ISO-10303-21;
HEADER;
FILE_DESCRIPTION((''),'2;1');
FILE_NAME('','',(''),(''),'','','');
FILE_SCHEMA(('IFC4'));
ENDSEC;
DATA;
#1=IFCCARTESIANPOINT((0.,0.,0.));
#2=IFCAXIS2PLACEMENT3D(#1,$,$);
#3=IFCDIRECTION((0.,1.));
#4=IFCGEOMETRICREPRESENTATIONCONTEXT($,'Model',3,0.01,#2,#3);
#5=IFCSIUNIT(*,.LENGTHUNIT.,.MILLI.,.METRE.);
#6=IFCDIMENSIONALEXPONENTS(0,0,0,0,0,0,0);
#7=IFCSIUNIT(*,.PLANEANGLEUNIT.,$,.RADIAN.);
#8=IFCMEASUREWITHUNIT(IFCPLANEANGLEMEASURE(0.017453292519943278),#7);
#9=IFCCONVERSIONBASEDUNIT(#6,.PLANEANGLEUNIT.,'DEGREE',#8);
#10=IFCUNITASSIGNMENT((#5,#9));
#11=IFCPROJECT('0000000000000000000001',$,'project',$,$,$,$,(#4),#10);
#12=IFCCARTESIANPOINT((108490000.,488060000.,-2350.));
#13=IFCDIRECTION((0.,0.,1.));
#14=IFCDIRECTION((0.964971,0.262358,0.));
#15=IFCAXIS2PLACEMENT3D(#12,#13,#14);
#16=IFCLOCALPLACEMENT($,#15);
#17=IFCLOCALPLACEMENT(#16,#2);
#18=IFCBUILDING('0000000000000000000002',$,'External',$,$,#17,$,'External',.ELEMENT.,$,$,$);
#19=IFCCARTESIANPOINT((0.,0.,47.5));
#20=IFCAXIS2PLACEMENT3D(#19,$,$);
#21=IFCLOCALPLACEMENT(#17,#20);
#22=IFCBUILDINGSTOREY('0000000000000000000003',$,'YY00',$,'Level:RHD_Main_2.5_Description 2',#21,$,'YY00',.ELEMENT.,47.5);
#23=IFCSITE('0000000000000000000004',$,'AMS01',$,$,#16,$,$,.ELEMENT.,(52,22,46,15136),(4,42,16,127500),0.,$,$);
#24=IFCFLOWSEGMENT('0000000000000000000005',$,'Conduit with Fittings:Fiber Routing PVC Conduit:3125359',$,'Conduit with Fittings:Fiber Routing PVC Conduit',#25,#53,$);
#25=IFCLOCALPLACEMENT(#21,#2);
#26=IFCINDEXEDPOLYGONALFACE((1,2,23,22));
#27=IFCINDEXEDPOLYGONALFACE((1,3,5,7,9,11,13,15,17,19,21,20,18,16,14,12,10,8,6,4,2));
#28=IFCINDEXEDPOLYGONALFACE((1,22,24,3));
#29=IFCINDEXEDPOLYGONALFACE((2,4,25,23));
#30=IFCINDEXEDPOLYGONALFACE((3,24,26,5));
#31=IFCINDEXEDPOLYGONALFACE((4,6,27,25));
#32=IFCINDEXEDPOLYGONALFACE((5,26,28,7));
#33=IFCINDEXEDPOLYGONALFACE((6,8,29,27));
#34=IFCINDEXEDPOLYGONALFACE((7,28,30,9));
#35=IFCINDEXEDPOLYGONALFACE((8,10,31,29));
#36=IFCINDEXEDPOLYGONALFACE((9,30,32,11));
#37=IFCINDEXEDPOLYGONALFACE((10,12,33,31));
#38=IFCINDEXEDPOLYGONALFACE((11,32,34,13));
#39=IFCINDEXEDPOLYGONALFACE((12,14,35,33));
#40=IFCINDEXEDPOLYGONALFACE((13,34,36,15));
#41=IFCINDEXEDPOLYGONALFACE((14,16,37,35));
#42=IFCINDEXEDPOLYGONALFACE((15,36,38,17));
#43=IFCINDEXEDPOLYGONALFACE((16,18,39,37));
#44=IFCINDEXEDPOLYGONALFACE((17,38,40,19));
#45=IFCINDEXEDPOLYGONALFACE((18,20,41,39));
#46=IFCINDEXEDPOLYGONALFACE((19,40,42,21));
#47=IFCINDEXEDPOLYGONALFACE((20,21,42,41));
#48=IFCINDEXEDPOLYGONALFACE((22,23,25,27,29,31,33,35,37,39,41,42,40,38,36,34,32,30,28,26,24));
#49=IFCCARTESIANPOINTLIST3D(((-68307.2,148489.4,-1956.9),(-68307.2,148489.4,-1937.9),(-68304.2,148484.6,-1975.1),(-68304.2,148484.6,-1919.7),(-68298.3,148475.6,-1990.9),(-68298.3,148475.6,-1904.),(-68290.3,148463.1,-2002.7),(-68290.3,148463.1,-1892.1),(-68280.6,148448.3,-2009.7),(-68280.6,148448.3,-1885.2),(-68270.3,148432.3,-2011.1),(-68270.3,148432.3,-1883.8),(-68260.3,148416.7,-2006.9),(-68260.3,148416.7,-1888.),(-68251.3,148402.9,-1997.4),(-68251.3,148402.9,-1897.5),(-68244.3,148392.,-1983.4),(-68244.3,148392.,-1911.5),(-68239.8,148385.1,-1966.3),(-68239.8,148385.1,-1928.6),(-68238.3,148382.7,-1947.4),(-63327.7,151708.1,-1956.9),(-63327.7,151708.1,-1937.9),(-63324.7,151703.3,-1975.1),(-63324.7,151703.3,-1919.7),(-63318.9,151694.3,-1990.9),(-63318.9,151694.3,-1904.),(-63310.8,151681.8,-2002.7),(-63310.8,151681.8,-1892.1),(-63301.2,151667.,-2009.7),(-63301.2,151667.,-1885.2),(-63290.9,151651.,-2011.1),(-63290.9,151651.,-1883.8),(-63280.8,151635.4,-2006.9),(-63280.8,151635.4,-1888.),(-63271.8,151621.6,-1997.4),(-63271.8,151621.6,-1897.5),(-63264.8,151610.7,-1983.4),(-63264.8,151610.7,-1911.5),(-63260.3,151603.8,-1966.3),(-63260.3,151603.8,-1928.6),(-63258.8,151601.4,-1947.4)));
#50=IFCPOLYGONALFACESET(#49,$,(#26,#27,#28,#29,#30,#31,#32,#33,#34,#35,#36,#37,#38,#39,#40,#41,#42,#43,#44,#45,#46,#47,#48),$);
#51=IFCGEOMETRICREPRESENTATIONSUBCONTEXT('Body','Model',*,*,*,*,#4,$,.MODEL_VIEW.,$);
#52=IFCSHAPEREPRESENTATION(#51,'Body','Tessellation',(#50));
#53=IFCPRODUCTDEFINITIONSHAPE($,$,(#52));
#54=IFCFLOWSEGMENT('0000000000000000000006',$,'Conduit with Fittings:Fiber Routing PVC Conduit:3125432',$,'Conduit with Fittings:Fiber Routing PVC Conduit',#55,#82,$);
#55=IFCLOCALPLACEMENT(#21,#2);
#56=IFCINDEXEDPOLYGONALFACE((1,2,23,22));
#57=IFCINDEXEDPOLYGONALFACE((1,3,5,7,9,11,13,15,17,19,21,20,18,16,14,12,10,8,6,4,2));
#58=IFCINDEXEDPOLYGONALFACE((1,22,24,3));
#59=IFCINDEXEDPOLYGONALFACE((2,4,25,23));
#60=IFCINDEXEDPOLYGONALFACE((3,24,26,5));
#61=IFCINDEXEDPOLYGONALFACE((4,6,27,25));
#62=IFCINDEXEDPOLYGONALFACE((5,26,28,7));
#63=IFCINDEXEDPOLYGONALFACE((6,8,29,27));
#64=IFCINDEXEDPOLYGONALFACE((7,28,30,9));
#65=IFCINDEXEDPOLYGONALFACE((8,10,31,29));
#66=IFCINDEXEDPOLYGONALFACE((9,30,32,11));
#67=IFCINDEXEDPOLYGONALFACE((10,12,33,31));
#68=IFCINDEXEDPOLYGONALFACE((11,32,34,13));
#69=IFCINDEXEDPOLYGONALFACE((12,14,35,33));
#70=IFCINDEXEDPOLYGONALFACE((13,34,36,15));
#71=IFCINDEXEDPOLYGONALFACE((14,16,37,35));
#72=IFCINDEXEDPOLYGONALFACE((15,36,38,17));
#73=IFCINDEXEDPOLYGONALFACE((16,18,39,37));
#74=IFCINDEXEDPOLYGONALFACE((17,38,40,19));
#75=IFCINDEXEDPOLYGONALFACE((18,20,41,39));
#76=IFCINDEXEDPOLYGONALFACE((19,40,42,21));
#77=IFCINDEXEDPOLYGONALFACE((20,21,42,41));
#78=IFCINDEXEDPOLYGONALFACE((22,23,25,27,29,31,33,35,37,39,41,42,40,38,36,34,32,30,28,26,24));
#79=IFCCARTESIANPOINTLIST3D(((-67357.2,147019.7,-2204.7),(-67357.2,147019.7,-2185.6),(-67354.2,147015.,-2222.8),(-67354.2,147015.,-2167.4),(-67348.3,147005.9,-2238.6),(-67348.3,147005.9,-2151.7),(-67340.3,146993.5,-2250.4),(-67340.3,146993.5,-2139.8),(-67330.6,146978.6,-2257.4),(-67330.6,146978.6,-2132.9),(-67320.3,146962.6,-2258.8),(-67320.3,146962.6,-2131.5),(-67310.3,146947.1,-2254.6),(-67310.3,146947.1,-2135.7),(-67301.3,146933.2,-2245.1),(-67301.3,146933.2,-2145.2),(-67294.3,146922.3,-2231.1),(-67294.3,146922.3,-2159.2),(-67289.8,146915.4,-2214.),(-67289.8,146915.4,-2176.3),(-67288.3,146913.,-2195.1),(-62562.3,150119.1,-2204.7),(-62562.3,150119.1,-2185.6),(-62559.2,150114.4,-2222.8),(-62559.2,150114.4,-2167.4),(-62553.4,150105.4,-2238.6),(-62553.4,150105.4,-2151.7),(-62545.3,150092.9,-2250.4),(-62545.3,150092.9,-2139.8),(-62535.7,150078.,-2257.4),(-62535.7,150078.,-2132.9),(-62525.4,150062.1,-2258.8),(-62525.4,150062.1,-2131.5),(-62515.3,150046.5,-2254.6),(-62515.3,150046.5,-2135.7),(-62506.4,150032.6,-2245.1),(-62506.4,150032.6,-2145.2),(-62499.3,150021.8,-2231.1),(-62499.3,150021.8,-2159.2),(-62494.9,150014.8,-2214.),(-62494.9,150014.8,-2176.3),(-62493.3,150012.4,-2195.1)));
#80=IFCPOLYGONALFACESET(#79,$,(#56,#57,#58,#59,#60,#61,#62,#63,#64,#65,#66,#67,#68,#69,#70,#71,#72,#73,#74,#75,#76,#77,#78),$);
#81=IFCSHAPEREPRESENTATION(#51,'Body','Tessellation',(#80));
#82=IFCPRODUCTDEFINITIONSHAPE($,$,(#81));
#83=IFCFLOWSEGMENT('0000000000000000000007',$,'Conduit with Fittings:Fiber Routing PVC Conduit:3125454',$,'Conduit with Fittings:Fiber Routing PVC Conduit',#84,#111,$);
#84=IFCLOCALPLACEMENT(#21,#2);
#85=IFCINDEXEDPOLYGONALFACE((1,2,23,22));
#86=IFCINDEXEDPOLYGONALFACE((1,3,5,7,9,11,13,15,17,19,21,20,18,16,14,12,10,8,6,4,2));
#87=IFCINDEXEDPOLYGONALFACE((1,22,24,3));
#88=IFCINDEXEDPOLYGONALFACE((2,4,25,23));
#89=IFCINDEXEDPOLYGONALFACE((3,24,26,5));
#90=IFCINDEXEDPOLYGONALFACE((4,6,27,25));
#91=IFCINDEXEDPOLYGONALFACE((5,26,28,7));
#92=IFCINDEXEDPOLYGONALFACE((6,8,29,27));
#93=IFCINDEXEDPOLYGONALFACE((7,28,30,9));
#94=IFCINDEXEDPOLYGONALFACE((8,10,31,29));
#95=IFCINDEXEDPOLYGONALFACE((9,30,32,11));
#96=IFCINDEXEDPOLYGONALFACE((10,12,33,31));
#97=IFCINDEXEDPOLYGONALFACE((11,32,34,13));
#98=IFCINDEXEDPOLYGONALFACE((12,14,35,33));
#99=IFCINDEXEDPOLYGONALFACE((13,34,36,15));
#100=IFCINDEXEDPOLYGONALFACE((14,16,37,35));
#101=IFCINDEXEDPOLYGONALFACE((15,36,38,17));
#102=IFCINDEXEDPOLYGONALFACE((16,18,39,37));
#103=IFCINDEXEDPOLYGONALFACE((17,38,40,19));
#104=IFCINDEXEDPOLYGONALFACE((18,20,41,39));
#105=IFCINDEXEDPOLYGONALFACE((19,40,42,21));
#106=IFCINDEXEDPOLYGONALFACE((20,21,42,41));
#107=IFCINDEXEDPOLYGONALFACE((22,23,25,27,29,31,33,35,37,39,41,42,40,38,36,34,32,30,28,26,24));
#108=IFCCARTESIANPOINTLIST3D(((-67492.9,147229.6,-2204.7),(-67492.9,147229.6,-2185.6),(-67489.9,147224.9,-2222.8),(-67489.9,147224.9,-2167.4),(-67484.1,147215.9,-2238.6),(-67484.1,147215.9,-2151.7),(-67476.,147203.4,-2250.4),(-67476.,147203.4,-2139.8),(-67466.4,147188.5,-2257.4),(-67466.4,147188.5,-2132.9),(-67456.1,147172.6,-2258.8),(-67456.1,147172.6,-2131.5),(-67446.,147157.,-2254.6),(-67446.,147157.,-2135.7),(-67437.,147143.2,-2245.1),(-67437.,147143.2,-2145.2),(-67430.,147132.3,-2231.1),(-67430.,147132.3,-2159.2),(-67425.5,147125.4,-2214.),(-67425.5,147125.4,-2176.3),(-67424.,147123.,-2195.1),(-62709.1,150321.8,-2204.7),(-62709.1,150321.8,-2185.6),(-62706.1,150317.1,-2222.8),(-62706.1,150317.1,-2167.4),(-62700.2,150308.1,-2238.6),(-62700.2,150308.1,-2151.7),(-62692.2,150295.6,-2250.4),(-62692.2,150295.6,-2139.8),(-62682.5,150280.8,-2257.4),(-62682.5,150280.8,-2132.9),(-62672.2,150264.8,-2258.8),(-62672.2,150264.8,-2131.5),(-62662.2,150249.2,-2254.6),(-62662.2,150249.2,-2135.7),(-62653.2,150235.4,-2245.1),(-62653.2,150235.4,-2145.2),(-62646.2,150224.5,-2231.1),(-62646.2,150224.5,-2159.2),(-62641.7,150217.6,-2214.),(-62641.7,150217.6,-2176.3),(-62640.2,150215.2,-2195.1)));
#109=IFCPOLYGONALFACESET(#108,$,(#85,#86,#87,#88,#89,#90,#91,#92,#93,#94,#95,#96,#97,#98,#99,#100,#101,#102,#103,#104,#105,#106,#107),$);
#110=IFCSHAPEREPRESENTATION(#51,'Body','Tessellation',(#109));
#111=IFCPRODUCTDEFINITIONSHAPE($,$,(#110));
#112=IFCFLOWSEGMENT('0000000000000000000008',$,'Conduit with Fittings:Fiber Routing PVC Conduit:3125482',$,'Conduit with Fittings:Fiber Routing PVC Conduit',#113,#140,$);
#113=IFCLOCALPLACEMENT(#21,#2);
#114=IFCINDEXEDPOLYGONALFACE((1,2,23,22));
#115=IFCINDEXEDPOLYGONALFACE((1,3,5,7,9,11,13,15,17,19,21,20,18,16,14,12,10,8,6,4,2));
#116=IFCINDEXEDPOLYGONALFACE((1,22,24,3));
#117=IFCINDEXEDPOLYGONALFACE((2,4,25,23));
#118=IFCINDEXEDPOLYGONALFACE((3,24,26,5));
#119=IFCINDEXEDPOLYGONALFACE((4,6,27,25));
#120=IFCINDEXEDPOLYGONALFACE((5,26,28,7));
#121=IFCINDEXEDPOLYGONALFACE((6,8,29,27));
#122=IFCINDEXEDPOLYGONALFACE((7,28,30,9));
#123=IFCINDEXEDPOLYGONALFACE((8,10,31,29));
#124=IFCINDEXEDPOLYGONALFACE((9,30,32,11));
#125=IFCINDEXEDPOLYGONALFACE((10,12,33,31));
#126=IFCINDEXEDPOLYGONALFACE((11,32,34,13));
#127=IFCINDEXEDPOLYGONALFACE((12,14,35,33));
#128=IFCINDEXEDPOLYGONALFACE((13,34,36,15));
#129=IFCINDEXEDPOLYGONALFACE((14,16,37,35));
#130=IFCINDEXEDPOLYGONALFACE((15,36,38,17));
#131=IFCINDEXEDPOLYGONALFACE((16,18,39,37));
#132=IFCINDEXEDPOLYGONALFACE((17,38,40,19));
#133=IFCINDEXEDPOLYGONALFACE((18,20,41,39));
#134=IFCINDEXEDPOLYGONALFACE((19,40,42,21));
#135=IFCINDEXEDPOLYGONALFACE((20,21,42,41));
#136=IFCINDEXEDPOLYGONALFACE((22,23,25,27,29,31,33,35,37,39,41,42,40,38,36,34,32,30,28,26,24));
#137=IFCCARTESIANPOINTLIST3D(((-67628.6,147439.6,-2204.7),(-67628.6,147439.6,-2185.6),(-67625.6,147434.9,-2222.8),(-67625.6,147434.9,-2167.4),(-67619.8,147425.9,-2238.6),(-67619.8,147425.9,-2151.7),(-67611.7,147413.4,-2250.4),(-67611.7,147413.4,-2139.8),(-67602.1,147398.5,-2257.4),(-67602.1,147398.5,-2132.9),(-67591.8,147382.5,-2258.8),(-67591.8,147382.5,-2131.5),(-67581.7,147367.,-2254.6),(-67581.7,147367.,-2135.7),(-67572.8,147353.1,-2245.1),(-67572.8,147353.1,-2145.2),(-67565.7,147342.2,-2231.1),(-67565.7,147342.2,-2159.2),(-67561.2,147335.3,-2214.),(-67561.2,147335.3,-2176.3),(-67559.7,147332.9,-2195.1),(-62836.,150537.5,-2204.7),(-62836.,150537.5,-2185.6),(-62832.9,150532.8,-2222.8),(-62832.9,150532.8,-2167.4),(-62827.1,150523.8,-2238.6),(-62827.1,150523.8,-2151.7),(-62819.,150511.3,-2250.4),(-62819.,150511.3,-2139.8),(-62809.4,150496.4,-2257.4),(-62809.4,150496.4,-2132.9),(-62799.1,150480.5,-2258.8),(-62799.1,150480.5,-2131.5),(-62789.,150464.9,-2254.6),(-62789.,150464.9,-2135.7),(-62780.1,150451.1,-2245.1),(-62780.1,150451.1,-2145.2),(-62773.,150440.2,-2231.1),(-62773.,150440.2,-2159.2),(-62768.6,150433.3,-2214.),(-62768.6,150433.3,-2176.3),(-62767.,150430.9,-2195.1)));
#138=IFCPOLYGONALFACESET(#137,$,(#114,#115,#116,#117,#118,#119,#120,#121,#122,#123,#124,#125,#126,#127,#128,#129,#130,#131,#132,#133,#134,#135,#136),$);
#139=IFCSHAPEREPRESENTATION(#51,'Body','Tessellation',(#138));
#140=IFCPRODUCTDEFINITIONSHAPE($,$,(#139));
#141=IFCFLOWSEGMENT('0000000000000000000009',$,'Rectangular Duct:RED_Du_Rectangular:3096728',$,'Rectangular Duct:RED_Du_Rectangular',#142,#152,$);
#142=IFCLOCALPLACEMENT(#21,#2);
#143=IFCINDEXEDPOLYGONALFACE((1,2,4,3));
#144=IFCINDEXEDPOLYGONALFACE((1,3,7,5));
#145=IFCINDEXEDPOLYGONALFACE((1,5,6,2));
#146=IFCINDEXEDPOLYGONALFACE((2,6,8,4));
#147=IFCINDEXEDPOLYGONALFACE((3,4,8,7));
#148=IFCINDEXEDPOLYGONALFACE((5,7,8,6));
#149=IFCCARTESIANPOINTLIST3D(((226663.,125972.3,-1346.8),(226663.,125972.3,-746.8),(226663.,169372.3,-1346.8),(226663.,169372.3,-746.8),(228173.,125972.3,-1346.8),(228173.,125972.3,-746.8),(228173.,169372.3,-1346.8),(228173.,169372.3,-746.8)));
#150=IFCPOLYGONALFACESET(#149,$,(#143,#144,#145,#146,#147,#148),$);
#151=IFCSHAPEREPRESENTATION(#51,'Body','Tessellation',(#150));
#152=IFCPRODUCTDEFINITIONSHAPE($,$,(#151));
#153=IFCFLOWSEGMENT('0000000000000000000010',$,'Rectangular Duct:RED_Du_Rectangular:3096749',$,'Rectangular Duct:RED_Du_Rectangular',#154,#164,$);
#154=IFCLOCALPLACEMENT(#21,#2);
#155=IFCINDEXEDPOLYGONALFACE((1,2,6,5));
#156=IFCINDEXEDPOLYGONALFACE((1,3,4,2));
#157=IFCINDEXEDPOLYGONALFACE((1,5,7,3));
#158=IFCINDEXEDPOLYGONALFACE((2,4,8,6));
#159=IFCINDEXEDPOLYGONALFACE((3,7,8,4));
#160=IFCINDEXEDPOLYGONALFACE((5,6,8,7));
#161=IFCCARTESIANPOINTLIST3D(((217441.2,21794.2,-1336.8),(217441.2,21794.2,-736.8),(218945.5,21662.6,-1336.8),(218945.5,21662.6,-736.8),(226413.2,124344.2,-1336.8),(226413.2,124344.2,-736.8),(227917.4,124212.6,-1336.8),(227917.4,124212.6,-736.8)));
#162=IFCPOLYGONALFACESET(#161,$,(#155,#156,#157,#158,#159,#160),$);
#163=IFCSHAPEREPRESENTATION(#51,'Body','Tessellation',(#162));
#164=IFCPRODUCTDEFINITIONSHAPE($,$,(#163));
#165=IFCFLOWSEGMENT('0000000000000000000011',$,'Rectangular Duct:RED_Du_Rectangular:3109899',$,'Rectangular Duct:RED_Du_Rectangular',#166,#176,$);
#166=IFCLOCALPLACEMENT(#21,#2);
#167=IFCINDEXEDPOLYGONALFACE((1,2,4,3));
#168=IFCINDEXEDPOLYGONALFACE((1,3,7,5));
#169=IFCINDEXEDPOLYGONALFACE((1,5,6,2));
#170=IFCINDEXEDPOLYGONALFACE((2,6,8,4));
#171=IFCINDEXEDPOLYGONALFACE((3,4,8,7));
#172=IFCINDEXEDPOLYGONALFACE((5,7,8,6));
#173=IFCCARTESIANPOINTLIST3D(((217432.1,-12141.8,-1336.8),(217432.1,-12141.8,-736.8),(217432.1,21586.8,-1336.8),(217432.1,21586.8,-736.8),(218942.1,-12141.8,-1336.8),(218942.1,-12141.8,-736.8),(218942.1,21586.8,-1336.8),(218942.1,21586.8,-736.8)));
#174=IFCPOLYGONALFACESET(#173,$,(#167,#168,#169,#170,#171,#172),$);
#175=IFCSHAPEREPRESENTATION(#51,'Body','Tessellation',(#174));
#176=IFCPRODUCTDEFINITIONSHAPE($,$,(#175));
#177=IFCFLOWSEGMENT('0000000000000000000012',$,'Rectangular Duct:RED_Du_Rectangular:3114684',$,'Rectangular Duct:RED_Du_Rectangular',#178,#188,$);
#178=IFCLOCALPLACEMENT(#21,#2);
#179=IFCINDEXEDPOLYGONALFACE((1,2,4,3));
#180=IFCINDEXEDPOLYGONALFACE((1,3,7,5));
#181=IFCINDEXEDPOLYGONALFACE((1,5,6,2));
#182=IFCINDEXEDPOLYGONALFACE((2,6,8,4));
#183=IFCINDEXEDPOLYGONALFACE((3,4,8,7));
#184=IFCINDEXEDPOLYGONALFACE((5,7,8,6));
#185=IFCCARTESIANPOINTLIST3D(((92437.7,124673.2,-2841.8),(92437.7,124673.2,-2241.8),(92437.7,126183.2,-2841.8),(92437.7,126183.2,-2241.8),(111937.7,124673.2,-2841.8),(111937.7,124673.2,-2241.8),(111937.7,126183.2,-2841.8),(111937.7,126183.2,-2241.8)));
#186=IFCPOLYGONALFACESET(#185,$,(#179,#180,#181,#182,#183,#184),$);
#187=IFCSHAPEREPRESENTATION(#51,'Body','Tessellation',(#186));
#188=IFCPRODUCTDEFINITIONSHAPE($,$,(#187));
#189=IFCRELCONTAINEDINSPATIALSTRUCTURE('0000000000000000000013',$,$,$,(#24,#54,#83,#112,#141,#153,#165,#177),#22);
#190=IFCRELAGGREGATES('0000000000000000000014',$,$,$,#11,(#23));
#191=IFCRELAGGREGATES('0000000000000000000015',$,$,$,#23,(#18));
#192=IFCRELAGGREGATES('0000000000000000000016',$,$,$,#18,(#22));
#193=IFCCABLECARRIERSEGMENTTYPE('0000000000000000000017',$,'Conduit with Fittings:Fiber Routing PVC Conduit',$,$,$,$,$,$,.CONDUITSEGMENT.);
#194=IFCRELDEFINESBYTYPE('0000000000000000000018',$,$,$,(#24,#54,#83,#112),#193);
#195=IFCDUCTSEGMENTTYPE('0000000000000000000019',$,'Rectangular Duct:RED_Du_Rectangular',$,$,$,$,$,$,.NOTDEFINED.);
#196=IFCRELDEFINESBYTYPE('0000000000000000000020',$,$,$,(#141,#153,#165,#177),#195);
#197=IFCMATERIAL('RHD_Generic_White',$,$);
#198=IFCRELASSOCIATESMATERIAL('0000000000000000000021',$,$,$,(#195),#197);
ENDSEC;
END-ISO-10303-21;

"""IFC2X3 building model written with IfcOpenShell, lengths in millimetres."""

from ifc_helpers import new_model, entity, si_unit, converted_unit, direction, frame, frame_2d, origin, origin_2d_with_axis, place, context, subcontext, project, spatial, rectangle, circle, extrude, material, type_object, element, save


model = new_model("IFC2X3")

# Units and contexts
model_context = context("Model", 3, precision=0.01, world=origin(), true_north=direction((0.0, 1.0)))
body_context = subcontext(model_context, "Body", "Model", "MODEL_VIEW")
ifc_project = project(units=[si_unit("LENGTHUNIT", "METRE", prefix="MILLI"), converted_unit("PLANEANGLEUNIT", "DEGREE", entity("IfcPlaneAngleMeasure", 0.017453292519943278), si_unit("PLANEANGLEUNIT", "RADIAN"), dimensions=[0, 0, 0, 0, 0, 0, 0])], contexts=[model_context])

# Site, building, storey
site_placement = place(None, frame((108490000.0, 488060000.0, -2350.0), z_axis=(0.0, 0.0, 1.0), x_axis=(0.964971, 0.262358, 0.0)))
site = spatial("IfcSite", under=ifc_project, at=site_placement, Name="AMS01", CompositionType="ELEMENT", RefLatitude=(52, 22, 46, 15136), RefLongitude=(4, 42, 16, 127500), RefElevation=0.0)
building_placement = place(site_placement, origin())
building = spatial("IfcBuilding", under=site, at=building_placement, Name="External", LongName="External", CompositionType="ELEMENT")
storey_placement = place(building_placement, frame((0.0, 0.0, 47.5)))
storey = spatial("IfcBuildingStorey", under=building, at=storey_placement, Name="YY00", ObjectType="Level:RHD_Main_2.5_Description 2", LongName="YY00", CompositionType="ELEMENT", Elevation=47.5)

# Flow segments
cable_carrier_segment_type = type_object("IfcCableCarrierSegmentType", Name="Conduit with Fittings:Fiber Routing PVC Conduit", PredefinedType="CONDUITSEGMENT")
flow_segment_1_placement = place(storey_placement, origin())
element("IfcFlowSegment", 1, at=flow_segment_1_placement, inside=storey, type_object=cable_carrier_segment_type, Name="Conduit with Fittings:Fiber Routing PVC Conduit:3125359", ObjectType="Conduit with Fittings:Fiber Routing PVC Conduit", context=body_context, shape_type="SweptSolid", body=[
    extrude(circle(Radius=63.9, at=origin_2d_with_axis()), frame((-68272.9, 148436.3, -1947.4), z_axis=(0.839826, 0.542856, 0.0), x_axis=(0.542856, -0.839826, 0.0)), (0.0, 0.0, 1.0), 5929.2),
])
flow_segment_2_placement = place(storey_placement, origin())
element("IfcFlowSegment", 2, at=flow_segment_2_placement, inside=storey, type_object=cable_carrier_segment_type, Name="Conduit with Fittings:Fiber Routing PVC Conduit:3125432", ObjectType="Conduit with Fittings:Fiber Routing PVC Conduit", context=body_context, shape_type="SweptSolid", body=[
    extrude(circle(Radius=63.9, at=origin_2d_with_axis()), frame((-67322.9, 146966.6, -2195.1), z_axis=(0.839826, 0.542856, 0.0), x_axis=(0.542856, -0.839826, 0.0)), (0.0, 0.0, 1.0), 5709.5),
])
flow_segment_3_placement = place(storey_placement, origin())
element("IfcFlowSegment", 3, at=flow_segment_3_placement, inside=storey, type_object=cable_carrier_segment_type, Name="Conduit with Fittings:Fiber Routing PVC Conduit:3125454", ObjectType="Conduit with Fittings:Fiber Routing PVC Conduit", context=body_context, shape_type="SweptSolid", body=[
    extrude(circle(Radius=63.9, at=origin_2d_with_axis()), frame((-67458.6, 147176.6, -2195.1), z_axis=(0.839826, 0.542856, 0.0), x_axis=(0.542856, -0.839826, 0.0)), (0.0, 0.0, 1.0), 5696.2),
])
flow_segment_4_placement = place(storey_placement, origin())
element("IfcFlowSegment", 4, at=flow_segment_4_placement, inside=storey, type_object=cable_carrier_segment_type, Name="Conduit with Fittings:Fiber Routing PVC Conduit:3125482", ObjectType="Conduit with Fittings:Fiber Routing PVC Conduit", context=body_context, shape_type="SweptSolid", body=[
    extrude(circle(Radius=63.9, at=frame_2d((0.0, 0.0), x_axis=(1.0, 0.0))), frame((-67594.4, 147386.6, -2195.1), z_axis=(0.839826, 0.542856, 0.0), x_axis=(0.542856, -0.839826, 0.0)), (0.0, 0.0, 1.0), 5706.8),
])
ifc_material = material(Name="RHD_Generic_White")
duct_segment_type = type_object("IfcDuctSegmentType", Name="Rectangular Duct:RED_Du_Rectangular", PredefinedType="NOTDEFINED", material=ifc_material)
flow_segment_5_placement = place(storey_placement, origin())
element("IfcFlowSegment", 5, at=flow_segment_5_placement, inside=storey, type_object=duct_segment_type, Name="Rectangular Duct:RED_Du_Rectangular:3096728", ObjectType="Rectangular Duct:RED_Du_Rectangular", context=body_context, shape_type="SweptSolid", body=[
    extrude(rectangle(XDim=43400.0, YDim=1510.0, at=frame_2d((0.0, 0.0), x_axis=(1.0, 0.0))), frame((227418.0, 147672.3, -1346.8), z_axis=(0.0, 0.0, 1.0), x_axis=(0.0, -1.0, 0.0)), (0.0, 0.0, 1.0), 600.0),
])
flow_segment_6_placement = place(storey_placement, origin())
element("IfcFlowSegment", 6, at=flow_segment_6_placement, inside=storey, type_object=duct_segment_type, Name="Rectangular Duct:RED_Du_Rectangular:3096749", ObjectType="Rectangular Duct:RED_Du_Rectangular", context=body_context, shape_type="SweptSolid", body=[
    extrude(rectangle(XDim=102941.7, YDim=1510.0, at=frame_2d((0.0, 0.0), x_axis=(1.0, 0.0))), frame((222679.3, 73003.4, -1336.8), z_axis=(0.0, 0.0, 1.0), x_axis=(-0.087156, -0.996195, 0.0)), (0.0, 0.0, 1.0), 600.0),
])
flow_segment_7_placement = place(storey_placement, origin())
element("IfcFlowSegment", 7, at=flow_segment_7_placement, inside=storey, type_object=duct_segment_type, Name="Rectangular Duct:RED_Du_Rectangular:3109899", ObjectType="Rectangular Duct:RED_Du_Rectangular", context=body_context, shape_type="SweptSolid", body=[
    extrude(rectangle(XDim=33728.7, YDim=1510.0, at=origin_2d_with_axis()), frame((218187.1, 4722.5, -1336.8), z_axis=(0.0, 0.0, 1.0), x_axis=(0.0, -1.0, 0.0)), (0.0, 0.0, 1.0), 600.0),
])
flow_segment_8_placement = place(storey_placement, origin())
element("IfcFlowSegment", 8, at=flow_segment_8_placement, inside=storey, type_object=duct_segment_type, Name="Rectangular Duct:RED_Du_Rectangular:3114684", ObjectType="Rectangular Duct:RED_Du_Rectangular", context=body_context, shape_type="SweptSolid", body=[
    extrude(rectangle(XDim=19500.0, YDim=1510.0, at=frame_2d((0.0, 0.0), x_axis=(1.0, 0.0))), frame((102187.7, 125428.2, -2841.8), z_axis=(0.0, 0.0, 1.0), x_axis=(-1.0, 0.0, 0.0)), (0.0, 0.0, 1.0), 600.0),
])

save(model, "model.ifc")
